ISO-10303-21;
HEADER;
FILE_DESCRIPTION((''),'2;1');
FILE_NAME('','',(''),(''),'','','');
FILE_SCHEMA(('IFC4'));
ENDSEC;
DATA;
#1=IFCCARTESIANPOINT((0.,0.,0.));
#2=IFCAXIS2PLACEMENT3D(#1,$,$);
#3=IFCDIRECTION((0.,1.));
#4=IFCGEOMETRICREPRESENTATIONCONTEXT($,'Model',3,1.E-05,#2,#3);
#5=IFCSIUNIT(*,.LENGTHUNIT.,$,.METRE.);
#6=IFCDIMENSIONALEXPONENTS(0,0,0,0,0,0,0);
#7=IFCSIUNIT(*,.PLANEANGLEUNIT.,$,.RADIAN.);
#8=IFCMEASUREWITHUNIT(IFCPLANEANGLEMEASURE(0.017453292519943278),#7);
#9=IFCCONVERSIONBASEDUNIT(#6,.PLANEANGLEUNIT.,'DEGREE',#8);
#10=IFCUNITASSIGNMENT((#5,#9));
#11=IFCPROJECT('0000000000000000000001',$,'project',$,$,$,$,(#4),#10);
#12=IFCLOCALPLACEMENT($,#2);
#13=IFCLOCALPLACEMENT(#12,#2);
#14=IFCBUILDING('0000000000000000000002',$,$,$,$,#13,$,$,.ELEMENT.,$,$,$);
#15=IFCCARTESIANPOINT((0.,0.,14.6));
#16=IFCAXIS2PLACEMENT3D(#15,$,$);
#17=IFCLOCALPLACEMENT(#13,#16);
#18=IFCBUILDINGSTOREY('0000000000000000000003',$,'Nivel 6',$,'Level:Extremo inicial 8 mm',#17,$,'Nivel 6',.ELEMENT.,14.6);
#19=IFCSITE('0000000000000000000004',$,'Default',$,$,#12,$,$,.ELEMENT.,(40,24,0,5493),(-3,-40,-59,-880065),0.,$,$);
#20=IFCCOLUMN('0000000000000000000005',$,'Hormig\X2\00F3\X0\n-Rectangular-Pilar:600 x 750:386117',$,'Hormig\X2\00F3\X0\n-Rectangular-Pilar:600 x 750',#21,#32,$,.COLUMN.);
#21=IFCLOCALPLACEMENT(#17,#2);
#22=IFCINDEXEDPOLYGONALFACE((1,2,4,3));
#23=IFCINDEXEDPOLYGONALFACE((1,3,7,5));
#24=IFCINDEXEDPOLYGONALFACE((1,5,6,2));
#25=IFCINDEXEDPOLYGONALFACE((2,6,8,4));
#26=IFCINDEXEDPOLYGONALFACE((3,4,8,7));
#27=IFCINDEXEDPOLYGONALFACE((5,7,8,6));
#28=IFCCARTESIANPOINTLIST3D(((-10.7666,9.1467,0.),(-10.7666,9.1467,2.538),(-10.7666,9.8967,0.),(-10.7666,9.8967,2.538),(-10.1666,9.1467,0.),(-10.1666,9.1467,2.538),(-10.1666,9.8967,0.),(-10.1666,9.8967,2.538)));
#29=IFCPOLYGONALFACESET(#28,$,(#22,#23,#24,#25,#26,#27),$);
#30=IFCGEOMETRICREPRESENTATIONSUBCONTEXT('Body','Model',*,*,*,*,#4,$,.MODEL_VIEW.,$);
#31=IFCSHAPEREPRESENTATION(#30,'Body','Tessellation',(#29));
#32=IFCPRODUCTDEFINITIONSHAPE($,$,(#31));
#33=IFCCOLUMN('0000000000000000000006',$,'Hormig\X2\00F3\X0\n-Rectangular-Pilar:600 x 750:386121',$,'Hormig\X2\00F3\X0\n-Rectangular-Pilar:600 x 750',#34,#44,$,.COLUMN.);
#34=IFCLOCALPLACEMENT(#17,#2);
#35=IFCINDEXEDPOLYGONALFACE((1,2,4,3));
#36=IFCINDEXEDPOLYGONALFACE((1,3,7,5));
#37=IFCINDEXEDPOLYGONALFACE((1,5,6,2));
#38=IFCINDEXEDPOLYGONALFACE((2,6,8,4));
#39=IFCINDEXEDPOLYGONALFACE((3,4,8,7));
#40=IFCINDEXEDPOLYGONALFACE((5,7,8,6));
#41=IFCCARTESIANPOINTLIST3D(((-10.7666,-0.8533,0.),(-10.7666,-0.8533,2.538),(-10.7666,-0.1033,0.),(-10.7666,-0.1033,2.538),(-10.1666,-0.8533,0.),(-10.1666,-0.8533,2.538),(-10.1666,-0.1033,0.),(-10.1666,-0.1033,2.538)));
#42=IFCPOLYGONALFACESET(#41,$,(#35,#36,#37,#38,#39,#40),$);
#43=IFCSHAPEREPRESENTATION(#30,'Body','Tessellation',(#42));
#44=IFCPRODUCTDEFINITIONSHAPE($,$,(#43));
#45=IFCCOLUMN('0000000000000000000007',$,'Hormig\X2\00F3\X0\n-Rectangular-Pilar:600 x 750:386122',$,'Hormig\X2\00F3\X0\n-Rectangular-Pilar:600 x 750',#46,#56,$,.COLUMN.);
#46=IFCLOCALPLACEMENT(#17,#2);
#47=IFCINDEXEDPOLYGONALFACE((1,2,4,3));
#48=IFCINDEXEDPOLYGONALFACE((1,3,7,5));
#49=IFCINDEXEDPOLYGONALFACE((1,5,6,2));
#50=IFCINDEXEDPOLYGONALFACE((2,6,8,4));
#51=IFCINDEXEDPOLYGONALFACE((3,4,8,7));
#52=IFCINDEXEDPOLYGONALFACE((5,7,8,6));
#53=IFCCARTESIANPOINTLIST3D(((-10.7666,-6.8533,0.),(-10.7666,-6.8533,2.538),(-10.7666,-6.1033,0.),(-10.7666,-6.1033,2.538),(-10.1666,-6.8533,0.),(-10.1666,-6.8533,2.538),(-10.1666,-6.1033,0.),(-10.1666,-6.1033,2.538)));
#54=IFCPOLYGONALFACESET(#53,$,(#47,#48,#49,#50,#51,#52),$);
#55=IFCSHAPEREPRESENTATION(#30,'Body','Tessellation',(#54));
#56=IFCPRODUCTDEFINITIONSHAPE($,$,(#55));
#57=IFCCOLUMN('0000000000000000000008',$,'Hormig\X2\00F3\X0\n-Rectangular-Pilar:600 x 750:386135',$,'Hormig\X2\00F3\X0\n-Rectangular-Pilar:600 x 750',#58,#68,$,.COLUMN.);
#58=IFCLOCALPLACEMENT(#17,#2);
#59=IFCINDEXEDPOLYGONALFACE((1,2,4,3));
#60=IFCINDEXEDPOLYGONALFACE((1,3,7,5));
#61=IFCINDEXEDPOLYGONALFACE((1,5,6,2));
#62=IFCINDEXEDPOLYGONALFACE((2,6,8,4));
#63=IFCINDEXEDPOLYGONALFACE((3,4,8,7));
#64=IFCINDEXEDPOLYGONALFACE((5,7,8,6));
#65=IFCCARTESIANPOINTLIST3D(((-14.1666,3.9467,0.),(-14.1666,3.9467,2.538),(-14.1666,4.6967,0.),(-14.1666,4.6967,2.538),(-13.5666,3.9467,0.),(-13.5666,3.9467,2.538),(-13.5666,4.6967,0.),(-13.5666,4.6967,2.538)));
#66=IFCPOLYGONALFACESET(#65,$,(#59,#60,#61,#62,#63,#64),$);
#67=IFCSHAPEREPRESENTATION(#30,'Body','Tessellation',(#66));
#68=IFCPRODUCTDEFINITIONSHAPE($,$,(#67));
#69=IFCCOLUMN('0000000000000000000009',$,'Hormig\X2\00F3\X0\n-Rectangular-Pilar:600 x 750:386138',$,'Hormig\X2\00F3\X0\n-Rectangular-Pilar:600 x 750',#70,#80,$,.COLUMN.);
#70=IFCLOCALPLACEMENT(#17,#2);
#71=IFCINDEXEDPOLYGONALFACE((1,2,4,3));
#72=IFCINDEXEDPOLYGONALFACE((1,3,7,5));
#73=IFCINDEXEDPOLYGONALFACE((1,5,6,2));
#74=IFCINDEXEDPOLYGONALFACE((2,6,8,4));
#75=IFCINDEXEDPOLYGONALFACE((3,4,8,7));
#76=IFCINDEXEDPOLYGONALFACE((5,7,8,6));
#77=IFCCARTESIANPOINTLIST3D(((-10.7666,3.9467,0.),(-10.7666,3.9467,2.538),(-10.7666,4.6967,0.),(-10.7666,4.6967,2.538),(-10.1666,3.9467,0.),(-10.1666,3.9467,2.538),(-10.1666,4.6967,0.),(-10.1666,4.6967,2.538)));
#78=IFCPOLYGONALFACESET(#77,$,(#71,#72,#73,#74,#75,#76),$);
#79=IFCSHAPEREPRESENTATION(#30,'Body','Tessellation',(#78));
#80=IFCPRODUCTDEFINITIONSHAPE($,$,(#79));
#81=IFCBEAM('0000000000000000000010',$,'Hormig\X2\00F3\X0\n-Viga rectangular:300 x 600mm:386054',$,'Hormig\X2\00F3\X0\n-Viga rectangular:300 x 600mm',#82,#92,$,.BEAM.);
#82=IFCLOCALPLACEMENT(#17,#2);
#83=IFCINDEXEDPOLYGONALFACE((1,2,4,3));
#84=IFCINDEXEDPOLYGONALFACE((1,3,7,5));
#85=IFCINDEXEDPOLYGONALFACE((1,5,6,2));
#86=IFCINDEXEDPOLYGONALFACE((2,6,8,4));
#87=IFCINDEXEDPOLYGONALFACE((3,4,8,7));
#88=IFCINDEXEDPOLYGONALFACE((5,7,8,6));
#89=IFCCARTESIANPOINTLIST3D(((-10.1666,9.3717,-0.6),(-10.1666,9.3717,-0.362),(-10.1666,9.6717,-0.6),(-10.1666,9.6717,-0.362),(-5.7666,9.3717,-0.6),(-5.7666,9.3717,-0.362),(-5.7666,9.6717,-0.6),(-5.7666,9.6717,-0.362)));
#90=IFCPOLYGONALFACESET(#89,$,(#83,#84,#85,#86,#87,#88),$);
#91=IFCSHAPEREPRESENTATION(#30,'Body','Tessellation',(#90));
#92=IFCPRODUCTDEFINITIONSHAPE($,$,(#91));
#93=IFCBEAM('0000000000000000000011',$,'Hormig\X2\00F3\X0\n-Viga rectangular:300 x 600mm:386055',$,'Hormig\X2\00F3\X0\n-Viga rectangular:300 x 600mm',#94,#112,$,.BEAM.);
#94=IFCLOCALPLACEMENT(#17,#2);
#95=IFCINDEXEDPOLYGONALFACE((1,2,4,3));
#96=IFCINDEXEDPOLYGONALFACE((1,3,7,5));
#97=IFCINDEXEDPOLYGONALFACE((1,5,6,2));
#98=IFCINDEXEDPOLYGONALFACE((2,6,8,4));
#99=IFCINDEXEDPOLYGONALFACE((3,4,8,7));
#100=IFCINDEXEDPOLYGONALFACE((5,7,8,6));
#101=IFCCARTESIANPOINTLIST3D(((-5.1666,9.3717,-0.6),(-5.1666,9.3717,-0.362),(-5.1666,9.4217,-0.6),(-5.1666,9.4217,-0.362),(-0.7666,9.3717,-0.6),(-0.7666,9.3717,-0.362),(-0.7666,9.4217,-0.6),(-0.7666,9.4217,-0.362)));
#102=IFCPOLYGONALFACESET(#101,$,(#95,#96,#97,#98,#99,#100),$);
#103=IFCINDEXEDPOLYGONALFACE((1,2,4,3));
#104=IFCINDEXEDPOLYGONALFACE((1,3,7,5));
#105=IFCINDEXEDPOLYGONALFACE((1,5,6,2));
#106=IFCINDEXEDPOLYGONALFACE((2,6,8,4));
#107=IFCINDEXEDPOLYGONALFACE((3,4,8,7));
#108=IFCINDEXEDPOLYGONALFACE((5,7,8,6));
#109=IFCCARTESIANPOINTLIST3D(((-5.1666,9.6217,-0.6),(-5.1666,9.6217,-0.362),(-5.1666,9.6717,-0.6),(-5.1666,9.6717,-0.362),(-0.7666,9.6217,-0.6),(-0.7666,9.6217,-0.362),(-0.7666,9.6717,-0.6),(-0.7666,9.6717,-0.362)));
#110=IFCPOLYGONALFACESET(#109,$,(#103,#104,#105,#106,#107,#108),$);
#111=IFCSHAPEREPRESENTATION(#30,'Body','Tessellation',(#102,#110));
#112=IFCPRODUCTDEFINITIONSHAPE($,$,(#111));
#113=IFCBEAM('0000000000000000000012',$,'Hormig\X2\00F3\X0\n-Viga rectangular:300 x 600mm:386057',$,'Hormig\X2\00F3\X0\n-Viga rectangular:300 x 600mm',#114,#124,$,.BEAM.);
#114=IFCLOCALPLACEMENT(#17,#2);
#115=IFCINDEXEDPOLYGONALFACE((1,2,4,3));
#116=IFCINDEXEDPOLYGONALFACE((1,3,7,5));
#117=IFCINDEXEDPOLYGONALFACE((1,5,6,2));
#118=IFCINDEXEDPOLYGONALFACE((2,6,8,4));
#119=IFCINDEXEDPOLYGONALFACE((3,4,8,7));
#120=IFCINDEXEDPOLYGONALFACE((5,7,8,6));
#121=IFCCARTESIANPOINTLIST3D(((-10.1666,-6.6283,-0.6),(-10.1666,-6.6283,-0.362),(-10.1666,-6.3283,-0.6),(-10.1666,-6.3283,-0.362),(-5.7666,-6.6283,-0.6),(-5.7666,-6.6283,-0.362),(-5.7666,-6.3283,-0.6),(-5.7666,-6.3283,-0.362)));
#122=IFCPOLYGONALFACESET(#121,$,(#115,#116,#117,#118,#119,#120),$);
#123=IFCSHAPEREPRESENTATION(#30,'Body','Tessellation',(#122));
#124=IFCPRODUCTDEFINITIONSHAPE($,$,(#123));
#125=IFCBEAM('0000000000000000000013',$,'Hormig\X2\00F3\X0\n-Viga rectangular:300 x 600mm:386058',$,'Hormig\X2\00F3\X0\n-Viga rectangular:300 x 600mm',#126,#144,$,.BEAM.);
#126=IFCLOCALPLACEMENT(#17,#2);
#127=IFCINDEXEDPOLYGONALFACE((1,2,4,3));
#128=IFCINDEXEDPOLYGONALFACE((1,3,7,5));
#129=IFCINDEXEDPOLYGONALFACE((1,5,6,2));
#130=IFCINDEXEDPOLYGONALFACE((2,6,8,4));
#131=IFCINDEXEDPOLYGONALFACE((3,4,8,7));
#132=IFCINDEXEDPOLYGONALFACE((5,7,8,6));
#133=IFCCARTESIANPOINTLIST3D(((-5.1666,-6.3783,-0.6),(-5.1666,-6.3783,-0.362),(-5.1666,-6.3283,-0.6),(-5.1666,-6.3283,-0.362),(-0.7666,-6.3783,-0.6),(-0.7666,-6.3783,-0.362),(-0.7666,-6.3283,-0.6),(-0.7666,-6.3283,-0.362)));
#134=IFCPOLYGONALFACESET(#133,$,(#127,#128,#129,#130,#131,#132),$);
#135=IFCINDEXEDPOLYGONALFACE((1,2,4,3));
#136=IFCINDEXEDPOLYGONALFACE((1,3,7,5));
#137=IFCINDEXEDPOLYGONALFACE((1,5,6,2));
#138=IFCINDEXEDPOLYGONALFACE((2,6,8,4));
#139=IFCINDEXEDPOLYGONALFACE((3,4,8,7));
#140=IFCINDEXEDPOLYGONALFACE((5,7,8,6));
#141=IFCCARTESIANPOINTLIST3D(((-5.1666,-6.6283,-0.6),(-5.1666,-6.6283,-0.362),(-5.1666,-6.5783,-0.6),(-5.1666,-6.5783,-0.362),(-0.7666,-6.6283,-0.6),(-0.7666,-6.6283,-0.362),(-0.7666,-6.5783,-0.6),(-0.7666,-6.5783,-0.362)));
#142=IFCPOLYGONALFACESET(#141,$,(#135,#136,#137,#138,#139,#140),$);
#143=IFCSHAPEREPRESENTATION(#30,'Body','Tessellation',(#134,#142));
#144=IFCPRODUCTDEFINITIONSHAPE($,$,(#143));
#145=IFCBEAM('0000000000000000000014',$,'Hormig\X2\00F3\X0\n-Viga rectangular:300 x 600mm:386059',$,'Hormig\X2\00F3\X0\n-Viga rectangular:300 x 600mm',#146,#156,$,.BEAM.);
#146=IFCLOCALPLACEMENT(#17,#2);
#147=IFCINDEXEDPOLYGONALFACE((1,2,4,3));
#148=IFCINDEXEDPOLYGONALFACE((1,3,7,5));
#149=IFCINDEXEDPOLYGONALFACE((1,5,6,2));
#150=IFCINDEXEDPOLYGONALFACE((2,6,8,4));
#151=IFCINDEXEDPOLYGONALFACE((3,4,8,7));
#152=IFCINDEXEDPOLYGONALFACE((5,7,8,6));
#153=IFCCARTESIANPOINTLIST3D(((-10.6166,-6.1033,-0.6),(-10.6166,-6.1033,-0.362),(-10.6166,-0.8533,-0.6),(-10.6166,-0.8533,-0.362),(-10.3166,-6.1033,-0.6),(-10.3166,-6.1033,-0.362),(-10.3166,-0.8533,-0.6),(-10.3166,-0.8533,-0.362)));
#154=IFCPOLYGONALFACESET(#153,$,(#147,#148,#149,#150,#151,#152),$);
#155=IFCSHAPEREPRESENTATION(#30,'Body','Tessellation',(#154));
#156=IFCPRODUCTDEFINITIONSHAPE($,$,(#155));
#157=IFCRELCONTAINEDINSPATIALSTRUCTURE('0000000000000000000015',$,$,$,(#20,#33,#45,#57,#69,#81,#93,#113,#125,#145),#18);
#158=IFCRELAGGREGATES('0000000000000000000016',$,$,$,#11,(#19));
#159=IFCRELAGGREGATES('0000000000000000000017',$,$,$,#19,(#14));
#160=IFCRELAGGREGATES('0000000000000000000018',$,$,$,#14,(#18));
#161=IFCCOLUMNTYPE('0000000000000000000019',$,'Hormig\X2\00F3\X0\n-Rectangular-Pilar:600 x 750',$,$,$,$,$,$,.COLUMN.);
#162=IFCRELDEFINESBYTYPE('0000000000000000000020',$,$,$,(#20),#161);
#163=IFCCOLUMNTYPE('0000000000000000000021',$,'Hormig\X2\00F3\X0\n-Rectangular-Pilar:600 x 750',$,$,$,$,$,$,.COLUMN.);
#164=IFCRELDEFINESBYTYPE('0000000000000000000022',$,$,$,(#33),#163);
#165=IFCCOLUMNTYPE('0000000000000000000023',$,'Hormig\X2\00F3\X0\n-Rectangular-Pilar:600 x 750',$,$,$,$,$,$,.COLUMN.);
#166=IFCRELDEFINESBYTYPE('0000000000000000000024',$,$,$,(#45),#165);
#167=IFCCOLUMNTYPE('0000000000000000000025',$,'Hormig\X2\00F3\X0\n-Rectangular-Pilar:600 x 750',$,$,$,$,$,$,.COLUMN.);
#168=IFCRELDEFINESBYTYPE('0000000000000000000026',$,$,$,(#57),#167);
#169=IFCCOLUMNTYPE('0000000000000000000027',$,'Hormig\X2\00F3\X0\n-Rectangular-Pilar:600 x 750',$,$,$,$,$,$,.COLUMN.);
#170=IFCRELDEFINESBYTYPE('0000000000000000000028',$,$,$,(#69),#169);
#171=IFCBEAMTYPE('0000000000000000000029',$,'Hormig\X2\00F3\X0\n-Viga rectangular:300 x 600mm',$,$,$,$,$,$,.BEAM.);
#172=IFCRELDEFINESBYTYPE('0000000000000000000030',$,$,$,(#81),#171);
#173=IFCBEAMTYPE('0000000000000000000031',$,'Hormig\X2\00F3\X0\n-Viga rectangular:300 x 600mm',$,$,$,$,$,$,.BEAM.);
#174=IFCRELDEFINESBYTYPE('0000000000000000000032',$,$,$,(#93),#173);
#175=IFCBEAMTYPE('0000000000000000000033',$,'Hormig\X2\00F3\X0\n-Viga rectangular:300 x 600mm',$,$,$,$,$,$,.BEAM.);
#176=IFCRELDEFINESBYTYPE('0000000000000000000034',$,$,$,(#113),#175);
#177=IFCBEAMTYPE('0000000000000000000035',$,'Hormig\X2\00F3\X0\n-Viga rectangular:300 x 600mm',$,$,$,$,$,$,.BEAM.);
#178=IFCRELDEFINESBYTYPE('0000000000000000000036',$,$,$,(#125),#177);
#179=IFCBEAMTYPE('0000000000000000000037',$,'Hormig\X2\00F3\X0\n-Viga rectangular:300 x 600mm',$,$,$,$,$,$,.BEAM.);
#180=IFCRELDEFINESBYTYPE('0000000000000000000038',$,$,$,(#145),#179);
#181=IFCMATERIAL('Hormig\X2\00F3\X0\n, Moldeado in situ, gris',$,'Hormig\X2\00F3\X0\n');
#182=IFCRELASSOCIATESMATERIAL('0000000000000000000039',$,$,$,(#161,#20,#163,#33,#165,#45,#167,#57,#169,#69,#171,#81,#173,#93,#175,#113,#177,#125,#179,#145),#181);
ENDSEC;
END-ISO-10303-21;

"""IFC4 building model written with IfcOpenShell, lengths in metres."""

from ifc_helpers import new_model, entity, si_unit, converted_unit, direction, frame, origin, place, context, subcontext, project, spatial, indexed_curve, outline, extrude, source, transform, mapped, material, type_object, type_shapes, element, save


model = new_model("IFC4")

# Units and contexts
model_context = context("Model", 3, precision=1e-05, world=origin(), true_north=direction((0.0, 1.0)))
body_context = subcontext(model_context, "Body", "Model", "MODEL_VIEW")
ifc_project = project(units=[si_unit("LENGTHUNIT", "METRE"), converted_unit("PLANEANGLEUNIT", "DEGREE", entity("IfcPlaneAngleMeasure", 0.017453292519943278), si_unit("PLANEANGLEUNIT", "RADIAN"), dimensions=[0, 0, 0, 0, 0, 0, 0])], contexts=[model_context])

# Site, building, storey
site_placement = place(None, origin())
site = spatial("IfcSite", under=ifc_project, at=site_placement, Name="Default", CompositionType="ELEMENT", RefLatitude=(40, 24, 0, 5493), RefLongitude=(-3, -40, -59, -880065), RefElevation=0.0)
building_placement = place(site_placement, origin())
building = spatial("IfcBuilding", under=site, at=building_placement, CompositionType="ELEMENT")
storey_placement = place(building_placement, frame((0.0, 0.0, 14.6)))
storey = spatial("IfcBuildingStorey", under=building, at=storey_placement, Name="Nivel 6", ObjectType="Level:Extremo inicial 8 mm", LongName="Nivel 6", CompositionType="ELEMENT", Elevation=14.6)

# Columns
ifc_material_1 = material(Name="Hormigón, Moldeado in situ, gris", Category="Hormigón")
column_type_1 = type_object("IfcColumnType", Name="Hormigón-Rectangular-Pilar:600 x 750", PredefinedType="COLUMN", material=ifc_material_1)
shared_shape_1 = source(origin(), body_context, "Body", "SweptSolid", [
    extrude(outline(indexed_curve([(-0.3, -0.375), (0.3, -0.375), (0.3, 0.375), (-0.3, 0.375), (-0.3, -0.375)], self_intersect=False)), frame((-10.4666, 9.5217, 14.6), z_axis=(0.0, 0.0, 1.0), x_axis=(-1.0, 0.0, 0.0)), (0.0, 0.0, 1.0), 2.538),
])
type_shapes(column_type_1, [shared_shape_1])
column_1_placement = place(storey_placement, frame((0.0, 0.0, -14.6)))
element("IfcColumn", 1, at=column_1_placement, inside=storey, type_object=column_type_1, material=ifc_material_1, Name="Hormigón-Rectangular-Pilar:600 x 750:386117", ObjectType="Hormigón-Rectangular-Pilar:600 x 750", PredefinedType="COLUMN", context=body_context, shape_type="MappedRepresentation", body=[
    mapped(shared_shape_1, transform((0.0, 0.0, 0.0), scale=1.0)),
])
column_type_2 = type_object("IfcColumnType", Name="Hormigón-Rectangular-Pilar:600 x 750", PredefinedType="COLUMN", material=ifc_material_1)
shared_shape_2 = source(origin(), body_context, "Body", "SweptSolid", [
    extrude(outline(indexed_curve([(-0.3, -0.375), (0.3, -0.375), (0.3, 0.375), (-0.3, 0.375), (-0.3, -0.375)], self_intersect=False)), frame((-10.4666, -0.4783, 14.6), z_axis=(0.0, 0.0, 1.0), x_axis=(-1.0, 0.0, 0.0)), (0.0, 0.0, 1.0), 2.538),
])
type_shapes(column_type_2, [shared_shape_2])
column_2_placement = place(storey_placement, frame((0.0, 0.0, -14.6)))
element("IfcColumn", 2, at=column_2_placement, inside=storey, type_object=column_type_2, material=ifc_material_1, Name="Hormigón-Rectangular-Pilar:600 x 750:386121", ObjectType="Hormigón-Rectangular-Pilar:600 x 750", PredefinedType="COLUMN", context=body_context, shape_type="MappedRepresentation", body=[
    mapped(shared_shape_2, transform((0.0, 0.0, 0.0), scale=1.0)),
])
column_type_3 = type_object("IfcColumnType", Name="Hormigón-Rectangular-Pilar:600 x 750", PredefinedType="COLUMN", material=ifc_material_1)
shared_shape_3 = source(origin(), body_context, "Body", "SweptSolid", [
    extrude(outline(indexed_curve([(-0.3, -0.375), (0.3, -0.375), (0.3, 0.375), (-0.3, 0.375), (-0.3, -0.375)], self_intersect=False)), frame((-10.4666, -6.4783, 14.6), z_axis=(0.0, 0.0, 1.0), x_axis=(-1.0, 0.0, 0.0)), (0.0, 0.0, 1.0), 2.538),
])
type_shapes(column_type_3, [shared_shape_3])
column_3_placement = place(storey_placement, frame((0.0, 0.0, -14.6)))
element("IfcColumn", 3, at=column_3_placement, inside=storey, type_object=column_type_3, material=ifc_material_1, Name="Hormigón-Rectangular-Pilar:600 x 750:386122", ObjectType="Hormigón-Rectangular-Pilar:600 x 750", PredefinedType="COLUMN", context=body_context, shape_type="MappedRepresentation", body=[
    mapped(shared_shape_3, transform((0.0, 0.0, 0.0), scale=1.0)),
])
column_type_4 = type_object("IfcColumnType", Name="Hormigón-Rectangular-Pilar:600 x 750", PredefinedType="COLUMN", material=ifc_material_1)
shared_shape_4 = source(origin(), body_context, "Body", "SweptSolid", [
    extrude(outline(indexed_curve([(-0.3, -0.375), (0.3, -0.375), (0.3, 0.375), (-0.3, 0.375), (-0.3, -0.375)], self_intersect=False)), frame((-13.8666, 4.3217, 14.6), z_axis=(0.0, 0.0, 1.0), x_axis=(-1.0, 0.0, 0.0)), (0.0, 0.0, 1.0), 2.538),
])
type_shapes(column_type_4, [shared_shape_4])
column_4_placement = place(storey_placement, frame((0.0, 0.0, -14.6)))
element("IfcColumn", 4, at=column_4_placement, inside=storey, type_object=column_type_4, material=ifc_material_1, Name="Hormigón-Rectangular-Pilar:600 x 750:386135", ObjectType="Hormigón-Rectangular-Pilar:600 x 750", PredefinedType="COLUMN", context=body_context, shape_type="MappedRepresentation", body=[
    mapped(shared_shape_4, transform((0.0, 0.0, 0.0), scale=1.0)),
])
column_type_5 = type_object("IfcColumnType", Name="Hormigón-Rectangular-Pilar:600 x 750", PredefinedType="COLUMN", material=ifc_material_1)
shared_shape_5 = source(origin(), body_context, "Body", "SweptSolid", [
    extrude(outline(indexed_curve([(-0.3, -0.375), (0.3, -0.375), (0.3, 0.375), (-0.3, 0.375), (-0.3, -0.375)], self_intersect=False)), frame((-10.4666, 4.3217, 14.6), z_axis=(0.0, 0.0, 1.0), x_axis=(-1.0, 0.0, 0.0)), (0.0, 0.0, 1.0), 2.538),
])
type_shapes(column_type_5, [shared_shape_5])
column_5_placement = place(storey_placement, frame((0.0, 0.0, -14.6)))
element("IfcColumn", 5, at=column_5_placement, inside=storey, type_object=column_type_5, material=ifc_material_1, Name="Hormigón-Rectangular-Pilar:600 x 750:386138", ObjectType="Hormigón-Rectangular-Pilar:600 x 750", PredefinedType="COLUMN", context=body_context, shape_type="MappedRepresentation", body=[
    mapped(shared_shape_5, transform((0.0, 0.0, 0.0), scale=1.0)),
])

# Beams
beam_type_1 = type_object("IfcBeamType", Name="Hormigón-Viga rectangular:300 x 600mm", PredefinedType="BEAM", material=ifc_material_1)
shared_shape_6 = source(origin(), body_context, "Body", "SweptSolid", [
    extrude(outline(indexed_curve([(-0.119, -0.15), (0.119, -0.15), (0.119, 0.15), (-0.119, 0.15), (-0.119, -0.15)], self_intersect=False)), frame((-5.7666, 9.5217, 14.119), z_axis=(-1.0, 0.0, 0.0), x_axis=(0.0, 0.0, -1.0)), (0.0, 0.0, 1.0), 4.4),
])
type_shapes(beam_type_1, [shared_shape_6])
beam_1_placement = place(storey_placement, frame((0.0, 0.0, -14.6)))
element("IfcBeam", 6, at=beam_1_placement, inside=storey, type_object=beam_type_1, material=ifc_material_1, Name="Hormigón-Viga rectangular:300 x 600mm:386054", ObjectType="Hormigón-Viga rectangular:300 x 600mm", PredefinedType="BEAM", context=body_context, shape_type="MappedRepresentation", body=[
    mapped(shared_shape_6, transform((0.0, 0.0, 0.0), scale=1.0)),
])
beam_type_2 = type_object("IfcBeamType", Name="Hormigón-Viga rectangular:300 x 600mm", PredefinedType="BEAM", material=ifc_material_1)
shared_shape_7 = source(origin(), body_context, "Body", "SweptSolid", [
    extrude(outline(indexed_curve([(-0.119, -0.025), (0.119, -0.025), (0.119, 0.025), (-0.119, 0.025), (-0.119, -0.025)], self_intersect=False)), frame((-5.1666, 9.3967, 14.119), z_axis=(1.0, 0.0, 0.0), x_axis=(0.0, 0.0, -1.0)), (0.0, 0.0, 1.0), 4.4),
    extrude(outline(indexed_curve([(-0.119, -0.025), (0.119, -0.025), (0.119, 0.025), (-0.119, 0.025), (-0.119, -0.025)], self_intersect=False)), frame((-5.1666, 9.6467, 14.119), z_axis=(1.0, 0.0, 0.0), x_axis=(0.0, 0.0, -1.0)), (0.0, 0.0, 1.0), 4.4),
])
type_shapes(beam_type_2, [shared_shape_7])
beam_2_placement = place(storey_placement, frame((0.0, 0.0, -14.6)))
element("IfcBeam", 7, at=beam_2_placement, inside=storey, type_object=beam_type_2, material=ifc_material_1, Name="Hormigón-Viga rectangular:300 x 600mm:386055", ObjectType="Hormigón-Viga rectangular:300 x 600mm", PredefinedType="BEAM", context=body_context, shape_type="MappedRepresentation", body=[
    mapped(shared_shape_7, transform((0.0, 0.0, 0.0), scale=1.0)),
])
beam_type_3 = type_object("IfcBeamType", Name="Hormigón-Viga rectangular:300 x 600mm", PredefinedType="BEAM", material=ifc_material_1)
shared_shape_8 = source(origin(), body_context, "Body", "SweptSolid", [
    extrude(outline(indexed_curve([(-0.119, -0.15), (0.119, -0.15), (0.119, 0.15), (-0.119, 0.15), (-0.119, -0.15)], self_intersect=False)), frame((-10.1666, -6.4783, 14.119), z_axis=(1.0, 0.0, 0.0), x_axis=(0.0, 0.0, -1.0)), (0.0, 0.0, 1.0), 4.4),
])
type_shapes(beam_type_3, [shared_shape_8])
beam_3_placement = place(storey_placement, frame((0.0, 0.0, -14.6)))
element("IfcBeam", 8, at=beam_3_placement, inside=storey, type_object=beam_type_3, material=ifc_material_1, Name="Hormigón-Viga rectangular:300 x 600mm:386057", ObjectType="Hormigón-Viga rectangular:300 x 600mm", PredefinedType="BEAM", context=body_context, shape_type="MappedRepresentation", body=[
    mapped(shared_shape_8, transform((0.0, 0.0, 0.0), scale=1.0)),
])
beam_type_4 = type_object("IfcBeamType", Name="Hormigón-Viga rectangular:300 x 600mm", PredefinedType="BEAM", material=ifc_material_1)
shared_shape_9 = source(origin(), body_context, "Body", "SweptSolid", [
    extrude(outline(indexed_curve([(-0.119, -0.025), (0.119, -0.025), (0.119, 0.025), (-0.119, 0.025), (-0.119, -0.025)], self_intersect=False)), frame((-0.7666, -6.3533, 14.119), z_axis=(-1.0, 0.0, 0.0), x_axis=(0.0, 0.0, -1.0)), (0.0, 0.0, 1.0), 4.4),
    extrude(outline(indexed_curve([(-0.119, -0.025), (0.119, -0.025), (0.119, 0.025), (-0.119, 0.025), (-0.119, -0.025)], self_intersect=False)), frame((-0.7666, -6.6033, 14.119), z_axis=(-1.0, 0.0, 0.0), x_axis=(0.0, 0.0, -1.0)), (0.0, 0.0, 1.0), 4.4),
])
type_shapes(beam_type_4, [shared_shape_9])
beam_4_placement = place(storey_placement, frame((0.0, 0.0, -14.6)))
element("IfcBeam", 9, at=beam_4_placement, inside=storey, type_object=beam_type_4, material=ifc_material_1, Name="Hormigón-Viga rectangular:300 x 600mm:386058", ObjectType="Hormigón-Viga rectangular:300 x 600mm", PredefinedType="BEAM", context=body_context, shape_type="MappedRepresentation", body=[
    mapped(shared_shape_9, transform((0.0, 0.0, 0.0), scale=1.0)),
])
beam_type_5 = type_object("IfcBeamType", Name="Hormigón-Viga rectangular:300 x 600mm", PredefinedType="BEAM", material=ifc_material_1)
shared_shape_10 = source(origin(), body_context, "Body", "SweptSolid", [
    extrude(outline(indexed_curve([(-0.15, -0.119), (0.15, -0.119), (0.15, 0.119), (-0.15, 0.119), (-0.15, -0.119)], self_intersect=False)), frame((-10.4666, -6.1033, 14.119), z_axis=(0.0, 1.0, 0.0), x_axis=(-1.0, 0.0, 0.0)), (0.0, 0.0, 1.0), 5.25),
])
type_shapes(beam_type_5, [shared_shape_10])
beam_5_placement = place(storey_placement, frame((0.0, 0.0, -14.6)))
element("IfcBeam", 10, at=beam_5_placement, inside=storey, type_object=beam_type_5, material=ifc_material_1, Name="Hormigón-Viga rectangular:300 x 600mm:386059", ObjectType="Hormigón-Viga rectangular:300 x 600mm", PredefinedType="BEAM", context=body_context, shape_type="MappedRepresentation", body=[
    mapped(shared_shape_10, transform((0.0, 0.0, 0.0), scale=1.0)),
])

save(model, "model.ifc")
